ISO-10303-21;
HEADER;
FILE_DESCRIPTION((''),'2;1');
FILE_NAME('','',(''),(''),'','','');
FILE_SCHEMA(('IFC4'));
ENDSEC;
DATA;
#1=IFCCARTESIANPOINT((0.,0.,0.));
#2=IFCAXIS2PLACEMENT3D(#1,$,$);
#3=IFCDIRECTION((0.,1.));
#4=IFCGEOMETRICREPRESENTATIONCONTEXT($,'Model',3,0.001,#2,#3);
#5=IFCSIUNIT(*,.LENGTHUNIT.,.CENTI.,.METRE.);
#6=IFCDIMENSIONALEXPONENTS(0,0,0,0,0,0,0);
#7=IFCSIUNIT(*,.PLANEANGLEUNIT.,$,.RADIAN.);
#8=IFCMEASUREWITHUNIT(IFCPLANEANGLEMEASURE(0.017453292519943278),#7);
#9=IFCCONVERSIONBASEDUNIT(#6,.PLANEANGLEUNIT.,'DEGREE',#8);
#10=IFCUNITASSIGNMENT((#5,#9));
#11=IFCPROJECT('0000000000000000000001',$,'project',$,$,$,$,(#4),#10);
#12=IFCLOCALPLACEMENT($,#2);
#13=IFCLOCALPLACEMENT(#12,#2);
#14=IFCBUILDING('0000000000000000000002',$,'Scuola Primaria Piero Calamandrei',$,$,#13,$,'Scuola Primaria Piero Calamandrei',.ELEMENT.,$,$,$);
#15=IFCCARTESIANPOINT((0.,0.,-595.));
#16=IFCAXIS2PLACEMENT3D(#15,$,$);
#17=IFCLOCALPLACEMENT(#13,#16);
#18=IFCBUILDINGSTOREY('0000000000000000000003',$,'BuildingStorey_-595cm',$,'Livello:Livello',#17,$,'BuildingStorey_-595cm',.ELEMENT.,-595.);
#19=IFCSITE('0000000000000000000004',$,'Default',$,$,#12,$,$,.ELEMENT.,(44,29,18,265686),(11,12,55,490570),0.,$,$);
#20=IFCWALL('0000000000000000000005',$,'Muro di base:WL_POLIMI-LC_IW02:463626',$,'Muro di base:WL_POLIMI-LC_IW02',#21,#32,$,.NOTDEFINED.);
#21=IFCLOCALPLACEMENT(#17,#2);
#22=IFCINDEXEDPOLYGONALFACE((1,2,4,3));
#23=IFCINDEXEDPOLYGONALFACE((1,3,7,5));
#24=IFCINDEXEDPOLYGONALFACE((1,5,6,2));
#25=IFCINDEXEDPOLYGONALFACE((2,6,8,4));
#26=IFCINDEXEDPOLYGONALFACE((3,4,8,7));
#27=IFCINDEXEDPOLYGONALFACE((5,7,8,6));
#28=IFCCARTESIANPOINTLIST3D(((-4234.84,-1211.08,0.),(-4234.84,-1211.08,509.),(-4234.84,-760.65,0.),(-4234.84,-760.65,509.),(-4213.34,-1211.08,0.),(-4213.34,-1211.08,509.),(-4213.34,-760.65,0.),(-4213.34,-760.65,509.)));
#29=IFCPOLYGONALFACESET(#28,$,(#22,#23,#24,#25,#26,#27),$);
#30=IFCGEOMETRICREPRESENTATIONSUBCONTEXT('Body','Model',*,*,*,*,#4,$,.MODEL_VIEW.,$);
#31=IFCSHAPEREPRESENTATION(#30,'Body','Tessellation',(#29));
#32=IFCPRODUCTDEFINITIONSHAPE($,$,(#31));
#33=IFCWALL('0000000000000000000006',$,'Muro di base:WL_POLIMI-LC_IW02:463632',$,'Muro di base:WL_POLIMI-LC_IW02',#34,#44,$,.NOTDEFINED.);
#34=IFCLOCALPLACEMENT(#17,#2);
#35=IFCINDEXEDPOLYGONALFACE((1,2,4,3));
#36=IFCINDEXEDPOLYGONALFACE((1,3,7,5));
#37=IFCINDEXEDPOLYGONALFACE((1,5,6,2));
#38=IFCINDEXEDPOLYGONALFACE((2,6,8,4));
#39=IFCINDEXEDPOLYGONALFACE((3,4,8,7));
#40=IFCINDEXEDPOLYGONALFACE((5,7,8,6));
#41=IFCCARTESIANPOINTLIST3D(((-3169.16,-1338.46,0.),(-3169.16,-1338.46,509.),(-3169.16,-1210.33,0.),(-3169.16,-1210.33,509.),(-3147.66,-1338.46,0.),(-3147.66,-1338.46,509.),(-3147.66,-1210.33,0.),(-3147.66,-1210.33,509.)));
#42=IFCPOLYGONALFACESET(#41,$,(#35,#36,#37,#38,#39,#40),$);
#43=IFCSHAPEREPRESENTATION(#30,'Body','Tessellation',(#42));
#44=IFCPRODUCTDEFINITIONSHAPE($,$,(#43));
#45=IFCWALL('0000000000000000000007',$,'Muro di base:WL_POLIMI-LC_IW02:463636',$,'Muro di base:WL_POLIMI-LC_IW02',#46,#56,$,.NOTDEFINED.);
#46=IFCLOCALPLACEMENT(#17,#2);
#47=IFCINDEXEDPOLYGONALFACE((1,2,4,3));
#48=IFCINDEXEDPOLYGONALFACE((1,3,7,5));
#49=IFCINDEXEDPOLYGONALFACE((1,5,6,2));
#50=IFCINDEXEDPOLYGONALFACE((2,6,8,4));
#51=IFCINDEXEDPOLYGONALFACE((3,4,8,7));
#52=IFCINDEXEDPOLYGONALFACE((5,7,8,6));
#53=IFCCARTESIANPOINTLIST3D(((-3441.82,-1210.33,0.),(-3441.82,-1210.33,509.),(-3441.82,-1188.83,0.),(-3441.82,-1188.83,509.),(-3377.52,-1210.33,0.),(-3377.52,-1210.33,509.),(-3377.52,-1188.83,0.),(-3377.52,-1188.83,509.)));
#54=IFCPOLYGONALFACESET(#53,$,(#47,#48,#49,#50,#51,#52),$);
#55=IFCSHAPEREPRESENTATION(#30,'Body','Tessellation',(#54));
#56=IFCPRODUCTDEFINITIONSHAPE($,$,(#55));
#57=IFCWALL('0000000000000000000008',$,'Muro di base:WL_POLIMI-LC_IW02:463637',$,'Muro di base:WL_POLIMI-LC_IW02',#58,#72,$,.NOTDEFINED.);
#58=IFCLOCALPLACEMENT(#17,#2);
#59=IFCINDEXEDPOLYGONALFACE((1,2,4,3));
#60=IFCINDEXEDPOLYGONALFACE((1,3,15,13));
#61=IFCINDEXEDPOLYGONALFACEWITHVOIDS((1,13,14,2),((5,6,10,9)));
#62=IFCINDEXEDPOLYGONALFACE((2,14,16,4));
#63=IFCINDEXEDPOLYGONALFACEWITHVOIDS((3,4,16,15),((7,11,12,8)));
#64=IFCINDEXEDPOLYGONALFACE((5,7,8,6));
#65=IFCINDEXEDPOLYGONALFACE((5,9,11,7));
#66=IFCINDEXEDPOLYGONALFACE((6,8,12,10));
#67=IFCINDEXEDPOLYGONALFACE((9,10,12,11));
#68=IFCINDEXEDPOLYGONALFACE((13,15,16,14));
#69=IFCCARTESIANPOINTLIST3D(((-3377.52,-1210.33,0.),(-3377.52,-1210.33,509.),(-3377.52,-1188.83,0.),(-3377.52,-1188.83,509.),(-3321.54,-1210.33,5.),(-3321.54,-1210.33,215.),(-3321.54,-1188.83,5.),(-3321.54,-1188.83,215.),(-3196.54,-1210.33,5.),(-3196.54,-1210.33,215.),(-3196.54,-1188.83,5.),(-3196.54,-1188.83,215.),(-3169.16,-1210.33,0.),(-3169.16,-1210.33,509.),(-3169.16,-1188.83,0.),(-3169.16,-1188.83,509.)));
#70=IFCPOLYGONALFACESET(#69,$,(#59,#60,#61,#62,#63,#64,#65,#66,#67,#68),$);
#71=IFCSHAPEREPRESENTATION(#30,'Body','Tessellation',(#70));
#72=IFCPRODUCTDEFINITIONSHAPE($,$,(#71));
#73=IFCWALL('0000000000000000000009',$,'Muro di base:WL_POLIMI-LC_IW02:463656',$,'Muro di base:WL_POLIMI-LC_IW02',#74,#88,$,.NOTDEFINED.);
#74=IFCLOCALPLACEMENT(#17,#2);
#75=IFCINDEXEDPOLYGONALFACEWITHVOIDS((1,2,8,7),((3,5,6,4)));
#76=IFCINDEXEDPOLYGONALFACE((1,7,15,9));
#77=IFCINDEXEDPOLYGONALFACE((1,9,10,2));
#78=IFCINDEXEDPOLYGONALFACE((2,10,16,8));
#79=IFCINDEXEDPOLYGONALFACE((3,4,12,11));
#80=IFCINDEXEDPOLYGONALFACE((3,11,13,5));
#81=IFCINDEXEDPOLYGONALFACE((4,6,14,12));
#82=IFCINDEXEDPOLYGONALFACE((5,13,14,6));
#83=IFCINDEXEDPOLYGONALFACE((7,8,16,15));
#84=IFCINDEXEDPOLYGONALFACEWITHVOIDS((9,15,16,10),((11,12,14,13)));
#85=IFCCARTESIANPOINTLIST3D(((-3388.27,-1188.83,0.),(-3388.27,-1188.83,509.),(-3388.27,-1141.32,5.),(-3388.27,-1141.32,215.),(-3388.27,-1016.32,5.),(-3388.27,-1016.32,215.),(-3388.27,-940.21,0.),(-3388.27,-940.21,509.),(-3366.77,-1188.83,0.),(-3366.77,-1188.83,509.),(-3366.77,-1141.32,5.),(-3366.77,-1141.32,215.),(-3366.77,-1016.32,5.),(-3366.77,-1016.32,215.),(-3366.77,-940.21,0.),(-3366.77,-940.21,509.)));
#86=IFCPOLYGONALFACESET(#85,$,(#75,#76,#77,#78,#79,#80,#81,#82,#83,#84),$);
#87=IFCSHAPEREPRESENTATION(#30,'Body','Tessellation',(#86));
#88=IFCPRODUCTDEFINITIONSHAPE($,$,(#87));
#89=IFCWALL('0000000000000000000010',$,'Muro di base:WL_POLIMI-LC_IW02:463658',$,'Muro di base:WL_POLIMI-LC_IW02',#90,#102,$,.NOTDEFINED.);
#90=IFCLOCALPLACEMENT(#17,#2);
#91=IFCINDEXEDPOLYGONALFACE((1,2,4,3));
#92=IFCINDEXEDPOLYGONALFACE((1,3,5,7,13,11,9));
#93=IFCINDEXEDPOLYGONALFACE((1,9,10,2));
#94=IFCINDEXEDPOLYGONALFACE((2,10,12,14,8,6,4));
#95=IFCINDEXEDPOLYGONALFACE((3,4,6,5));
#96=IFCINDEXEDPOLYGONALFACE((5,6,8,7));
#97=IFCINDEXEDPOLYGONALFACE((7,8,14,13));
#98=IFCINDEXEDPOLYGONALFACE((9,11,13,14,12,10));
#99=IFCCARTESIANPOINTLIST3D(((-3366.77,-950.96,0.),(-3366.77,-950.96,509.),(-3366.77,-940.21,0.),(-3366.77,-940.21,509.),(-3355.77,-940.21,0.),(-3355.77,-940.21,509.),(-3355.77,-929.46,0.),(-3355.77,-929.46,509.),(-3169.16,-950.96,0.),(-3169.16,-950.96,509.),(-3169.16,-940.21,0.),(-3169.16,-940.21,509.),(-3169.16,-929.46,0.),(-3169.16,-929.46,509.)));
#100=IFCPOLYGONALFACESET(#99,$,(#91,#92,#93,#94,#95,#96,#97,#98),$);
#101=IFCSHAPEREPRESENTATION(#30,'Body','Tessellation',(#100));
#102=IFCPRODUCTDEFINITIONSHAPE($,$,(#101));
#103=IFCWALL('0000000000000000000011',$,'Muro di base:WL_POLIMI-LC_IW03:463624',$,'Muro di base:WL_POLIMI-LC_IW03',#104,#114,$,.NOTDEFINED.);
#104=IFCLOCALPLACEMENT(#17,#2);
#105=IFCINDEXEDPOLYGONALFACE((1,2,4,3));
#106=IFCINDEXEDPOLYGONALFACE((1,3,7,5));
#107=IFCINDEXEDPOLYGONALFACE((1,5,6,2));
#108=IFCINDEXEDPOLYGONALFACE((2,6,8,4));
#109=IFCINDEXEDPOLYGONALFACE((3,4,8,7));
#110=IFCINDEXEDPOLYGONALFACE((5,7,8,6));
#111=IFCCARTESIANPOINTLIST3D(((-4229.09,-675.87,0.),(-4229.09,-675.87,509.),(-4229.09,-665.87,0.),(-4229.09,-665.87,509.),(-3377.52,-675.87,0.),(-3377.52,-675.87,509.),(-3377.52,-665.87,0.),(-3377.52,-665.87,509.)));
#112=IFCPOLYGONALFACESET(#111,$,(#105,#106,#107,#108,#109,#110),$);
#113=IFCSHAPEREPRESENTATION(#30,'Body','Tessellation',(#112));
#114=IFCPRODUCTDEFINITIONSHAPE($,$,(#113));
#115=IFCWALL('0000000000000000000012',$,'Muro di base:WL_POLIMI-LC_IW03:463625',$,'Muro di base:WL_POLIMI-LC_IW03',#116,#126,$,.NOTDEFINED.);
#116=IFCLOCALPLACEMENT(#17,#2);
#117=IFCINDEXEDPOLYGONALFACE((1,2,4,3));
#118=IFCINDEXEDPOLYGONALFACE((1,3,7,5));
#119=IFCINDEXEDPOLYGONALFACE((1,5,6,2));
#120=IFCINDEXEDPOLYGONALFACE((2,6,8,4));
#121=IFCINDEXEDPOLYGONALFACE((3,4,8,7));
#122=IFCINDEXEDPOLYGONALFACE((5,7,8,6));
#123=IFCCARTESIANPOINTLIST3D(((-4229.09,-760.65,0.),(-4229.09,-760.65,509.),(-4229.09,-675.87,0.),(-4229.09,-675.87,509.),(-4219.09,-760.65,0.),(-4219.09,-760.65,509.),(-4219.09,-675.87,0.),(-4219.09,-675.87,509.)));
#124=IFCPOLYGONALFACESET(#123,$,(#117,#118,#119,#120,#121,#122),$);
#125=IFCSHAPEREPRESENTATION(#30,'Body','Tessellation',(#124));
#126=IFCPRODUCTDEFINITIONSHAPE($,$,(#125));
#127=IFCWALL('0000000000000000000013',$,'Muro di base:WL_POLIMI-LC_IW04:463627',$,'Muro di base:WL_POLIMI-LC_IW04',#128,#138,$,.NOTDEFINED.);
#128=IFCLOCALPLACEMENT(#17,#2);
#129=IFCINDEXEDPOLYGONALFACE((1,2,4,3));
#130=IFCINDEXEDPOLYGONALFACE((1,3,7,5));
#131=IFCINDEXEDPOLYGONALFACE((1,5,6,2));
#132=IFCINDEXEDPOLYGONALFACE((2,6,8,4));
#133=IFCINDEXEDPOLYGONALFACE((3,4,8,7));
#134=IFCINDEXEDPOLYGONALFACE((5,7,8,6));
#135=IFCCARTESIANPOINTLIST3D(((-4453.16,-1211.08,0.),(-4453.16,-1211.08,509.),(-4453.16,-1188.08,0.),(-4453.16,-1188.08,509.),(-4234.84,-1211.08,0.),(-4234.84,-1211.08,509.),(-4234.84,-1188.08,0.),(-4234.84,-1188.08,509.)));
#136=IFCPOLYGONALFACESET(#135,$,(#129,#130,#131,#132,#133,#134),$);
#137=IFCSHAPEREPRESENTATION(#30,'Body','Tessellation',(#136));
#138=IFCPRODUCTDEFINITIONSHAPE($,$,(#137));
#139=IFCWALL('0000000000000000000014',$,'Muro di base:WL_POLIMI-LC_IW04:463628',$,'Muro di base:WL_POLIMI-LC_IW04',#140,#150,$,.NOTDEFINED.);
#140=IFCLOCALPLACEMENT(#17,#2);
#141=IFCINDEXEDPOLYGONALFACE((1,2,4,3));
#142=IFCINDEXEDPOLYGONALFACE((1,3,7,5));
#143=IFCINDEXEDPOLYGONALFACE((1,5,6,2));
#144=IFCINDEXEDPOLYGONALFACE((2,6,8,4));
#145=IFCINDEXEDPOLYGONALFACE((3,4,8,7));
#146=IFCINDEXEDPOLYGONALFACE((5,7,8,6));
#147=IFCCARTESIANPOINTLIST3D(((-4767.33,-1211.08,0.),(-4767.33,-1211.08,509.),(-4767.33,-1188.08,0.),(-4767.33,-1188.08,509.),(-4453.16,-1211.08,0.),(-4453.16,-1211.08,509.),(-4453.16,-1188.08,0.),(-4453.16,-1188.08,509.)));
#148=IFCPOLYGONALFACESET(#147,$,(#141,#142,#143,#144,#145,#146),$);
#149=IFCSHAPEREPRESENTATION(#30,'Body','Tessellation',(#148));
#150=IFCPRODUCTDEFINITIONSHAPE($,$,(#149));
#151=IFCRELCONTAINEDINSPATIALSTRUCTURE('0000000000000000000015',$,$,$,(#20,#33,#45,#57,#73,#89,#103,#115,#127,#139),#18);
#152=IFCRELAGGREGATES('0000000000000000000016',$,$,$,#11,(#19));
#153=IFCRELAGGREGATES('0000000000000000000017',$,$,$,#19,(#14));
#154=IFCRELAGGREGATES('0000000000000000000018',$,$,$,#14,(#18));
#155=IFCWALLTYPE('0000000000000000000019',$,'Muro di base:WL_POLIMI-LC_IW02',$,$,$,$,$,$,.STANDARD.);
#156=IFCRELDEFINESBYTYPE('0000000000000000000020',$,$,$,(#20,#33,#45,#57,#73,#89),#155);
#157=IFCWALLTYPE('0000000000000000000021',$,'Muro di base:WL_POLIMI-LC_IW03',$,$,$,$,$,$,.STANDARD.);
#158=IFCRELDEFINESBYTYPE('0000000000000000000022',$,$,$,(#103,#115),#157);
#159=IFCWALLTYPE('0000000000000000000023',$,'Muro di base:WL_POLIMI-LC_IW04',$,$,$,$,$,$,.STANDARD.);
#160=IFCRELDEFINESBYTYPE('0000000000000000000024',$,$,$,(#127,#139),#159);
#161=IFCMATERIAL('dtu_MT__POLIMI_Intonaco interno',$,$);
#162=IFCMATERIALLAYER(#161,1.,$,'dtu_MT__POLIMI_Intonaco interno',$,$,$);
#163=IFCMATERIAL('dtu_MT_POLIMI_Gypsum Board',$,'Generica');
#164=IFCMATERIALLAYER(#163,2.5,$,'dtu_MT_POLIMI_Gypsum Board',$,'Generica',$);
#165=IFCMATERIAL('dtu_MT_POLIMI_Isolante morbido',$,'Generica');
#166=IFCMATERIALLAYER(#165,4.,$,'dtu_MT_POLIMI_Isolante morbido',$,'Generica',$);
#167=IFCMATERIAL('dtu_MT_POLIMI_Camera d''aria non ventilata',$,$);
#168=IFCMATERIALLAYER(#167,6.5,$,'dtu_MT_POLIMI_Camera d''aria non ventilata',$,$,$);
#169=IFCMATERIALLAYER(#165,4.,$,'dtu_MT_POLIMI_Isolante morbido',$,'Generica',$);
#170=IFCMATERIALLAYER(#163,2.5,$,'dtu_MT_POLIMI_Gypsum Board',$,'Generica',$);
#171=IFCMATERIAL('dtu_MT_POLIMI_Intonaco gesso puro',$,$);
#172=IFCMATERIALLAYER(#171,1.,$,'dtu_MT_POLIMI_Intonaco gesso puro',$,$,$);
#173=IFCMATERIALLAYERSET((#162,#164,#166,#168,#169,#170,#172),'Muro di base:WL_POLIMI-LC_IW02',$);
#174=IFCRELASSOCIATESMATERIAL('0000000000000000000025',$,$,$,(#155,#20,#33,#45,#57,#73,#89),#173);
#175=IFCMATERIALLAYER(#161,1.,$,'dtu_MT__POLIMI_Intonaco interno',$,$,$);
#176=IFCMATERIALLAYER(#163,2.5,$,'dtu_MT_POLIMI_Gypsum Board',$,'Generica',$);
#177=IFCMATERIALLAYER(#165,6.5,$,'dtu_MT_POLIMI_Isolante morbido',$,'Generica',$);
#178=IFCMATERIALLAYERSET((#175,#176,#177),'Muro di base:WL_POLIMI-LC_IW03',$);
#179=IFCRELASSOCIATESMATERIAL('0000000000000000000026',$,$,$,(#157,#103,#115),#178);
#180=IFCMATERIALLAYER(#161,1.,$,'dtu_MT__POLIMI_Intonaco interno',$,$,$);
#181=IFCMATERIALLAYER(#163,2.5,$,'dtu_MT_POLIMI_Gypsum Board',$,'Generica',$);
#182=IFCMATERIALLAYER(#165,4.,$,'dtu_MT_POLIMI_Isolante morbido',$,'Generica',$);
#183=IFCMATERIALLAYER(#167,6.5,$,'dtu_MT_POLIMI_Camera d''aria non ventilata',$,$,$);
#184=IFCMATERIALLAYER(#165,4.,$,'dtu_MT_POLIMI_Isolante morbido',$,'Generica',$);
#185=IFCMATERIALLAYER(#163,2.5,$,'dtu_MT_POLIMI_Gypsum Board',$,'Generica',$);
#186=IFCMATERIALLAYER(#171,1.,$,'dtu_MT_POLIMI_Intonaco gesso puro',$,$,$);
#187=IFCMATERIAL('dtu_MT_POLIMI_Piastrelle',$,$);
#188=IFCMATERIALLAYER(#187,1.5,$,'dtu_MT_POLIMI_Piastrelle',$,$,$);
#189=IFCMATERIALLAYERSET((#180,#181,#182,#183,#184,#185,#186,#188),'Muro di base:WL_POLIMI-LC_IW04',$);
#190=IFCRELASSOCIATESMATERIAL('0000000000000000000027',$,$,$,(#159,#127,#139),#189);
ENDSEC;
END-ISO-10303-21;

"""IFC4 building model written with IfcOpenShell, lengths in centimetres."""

from ifc_helpers import new_model, entity, si_unit, converted_unit, direction, frame, frame_2d, origin, place, context, subcontext, project, spatial, polyline, rectangle, outline, extrude, material, layer, layer_set, layer_usage, type_object, element, save


model = new_model("IFC4")

# Units and contexts
model_context = context("Model", 3, precision=0.001, world=origin(), true_north=direction((0.0, 1.0)))
body_context = subcontext(model_context, "Body", "Model", "MODEL_VIEW")
ifc_project = project(units=[si_unit("LENGTHUNIT", "METRE", prefix="CENTI"), converted_unit("PLANEANGLEUNIT", "DEGREE", entity("IfcPlaneAngleMeasure", 0.017453292519943278), si_unit("PLANEANGLEUNIT", "RADIAN"), dimensions=[0, 0, 0, 0, 0, 0, 0])], contexts=[model_context])

# Site, building, storey
site_placement = place(None, origin())
site = spatial("IfcSite", under=ifc_project, at=site_placement, Name="Default", CompositionType="ELEMENT", RefLatitude=(44, 29, 18, 265686), RefLongitude=(11, 12, 55, 490570), RefElevation=0.0)
building_placement = place(site_placement, origin())
building = spatial("IfcBuilding", under=site, at=building_placement, Name="Scuola Primaria Piero Calamandrei", LongName="Scuola Primaria Piero Calamandrei", CompositionType="ELEMENT")
storey_placement = place(building_placement, frame((0.0, 0.0, -595.0)))
storey = spatial("IfcBuildingStorey", under=building, at=storey_placement, Name="BuildingStorey_-595cm", ObjectType="Livello:Livello", LongName="BuildingStorey_-595cm", CompositionType="ELEMENT", Elevation=-595.0)

# Shared definitions
ifc_material_1 = material(Name="dtu_MT__POLIMI_Intonaco interno")
ifc_layer_1 = layer(ifc_material_1, 1.0, Name="dtu_MT__POLIMI_Intonaco interno")
ifc_material_2 = material(Name="dtu_MT_POLIMI_Gypsum Board", Category="Generica")
ifc_layer_2 = layer(ifc_material_2, 2.5, Name="dtu_MT_POLIMI_Gypsum Board", Category="Generica")
ifc_material_3 = material(Name="dtu_MT_POLIMI_Isolante morbido", Category="Generica")
ifc_layer_3 = layer(ifc_material_3, 4.0, Name="dtu_MT_POLIMI_Isolante morbido", Category="Generica")
ifc_material_4 = material(Name="dtu_MT_POLIMI_Camera d'aria non ventilata")
ifc_layer_4 = layer(ifc_material_4, 6.5, Name="dtu_MT_POLIMI_Camera d'aria non ventilata")
ifc_layer_5 = layer(ifc_material_3, 4.0, Name="dtu_MT_POLIMI_Isolante morbido", Category="Generica")
ifc_layer_6 = layer(ifc_material_2, 2.5, Name="dtu_MT_POLIMI_Gypsum Board", Category="Generica")
ifc_material_5 = material(Name="dtu_MT_POLIMI_Intonaco gesso puro")
ifc_layer_7 = layer(ifc_material_5, 1.0, Name="dtu_MT_POLIMI_Intonaco gesso puro")
ifc_layer_set_1 = layer_set([ifc_layer_1, ifc_layer_2, ifc_layer_3, ifc_layer_4, ifc_layer_5, ifc_layer_6, ifc_layer_7], Name="Muro di base:WL_POLIMI-LC_IW02")
wall_type_1 = type_object("IfcWallType", Name="Muro di base:WL_POLIMI-LC_IW02", PredefinedType="STANDARD", material=ifc_layer_set_1)

# Walls
ifc_layer_usage_1 = layer_usage(ifc_layer_set_1, "AXIS2", "NEGATIVE", 10.75)
wall_1_placement = place(storey_placement, frame((-4224.09, -760.65, 0.0), z_axis=(0.0, 0.0, 1.0), x_axis=(0.0, -1.0, 0.0)))
element("IfcWall", 1, at=wall_1_placement, inside=storey, type_object=wall_type_1, material=ifc_layer_usage_1, Name="Muro di base:WL_POLIMI-LC_IW02:463626", ObjectType="Muro di base:WL_POLIMI-LC_IW02", PredefinedType="NOTDEFINED", context=body_context, shape_type="SweptSolid", body=[
    extrude(rectangle(XDim=450.42, YDim=21.5, at=frame_2d((225.21, 0.0), x_axis=(-1.0, 0.0))), origin(), (0.0, 0.0, 1.0), 509.0),
])
ifc_layer_usage_2 = layer_usage(ifc_layer_set_1, "AXIS2", "NEGATIVE", 10.75)
wall_2_placement = place(storey_placement, frame((-3158.41, -1338.46, 0.0), z_axis=(0.0, 0.0, 1.0), x_axis=(0.0, 1.0, 0.0)))
element("IfcWall", 2, at=wall_2_placement, inside=storey, type_object=wall_type_1, material=ifc_layer_usage_2, Name="Muro di base:WL_POLIMI-LC_IW02:463632", ObjectType="Muro di base:WL_POLIMI-LC_IW02", PredefinedType="NOTDEFINED", context=body_context, shape_type="SweptSolid", body=[
    extrude(rectangle(XDim=128.13, YDim=21.5, at=frame_2d((64.07, 0.0), x_axis=(-1.0, 0.0))), origin(), (0.0, 0.0, 1.0), 509.0),
])
ifc_layer_usage_3 = layer_usage(ifc_layer_set_1, "AXIS2", "NEGATIVE", 10.75)
wall_3_placement = place(storey_placement, frame((-3441.82, -1199.58, 0.0)))
element("IfcWall", 3, at=wall_3_placement, inside=storey, type_object=wall_type_1, material=ifc_layer_usage_3, Name="Muro di base:WL_POLIMI-LC_IW02:463636", ObjectType="Muro di base:WL_POLIMI-LC_IW02", PredefinedType="NOTDEFINED", context=body_context, shape_type="SweptSolid", body=[
    extrude(rectangle(XDim=64.3, YDim=21.5, at=frame_2d((32.15, 0.0), x_axis=(-1.0, 0.0))), origin(), (0.0, 0.0, 1.0), 509.0),
])

# Walls, openings
ifc_layer_usage_4 = layer_usage(ifc_layer_set_1, "AXIS2", "NEGATIVE", 10.75)
wall_4_placement = place(storey_placement, frame((-3377.52, -1199.58, 0.0)))
wall_4 = element("IfcWall", 4, at=wall_4_placement, inside=storey, type_object=wall_type_1, material=ifc_layer_usage_4, Name="Muro di base:WL_POLIMI-LC_IW02:463637", ObjectType="Muro di base:WL_POLIMI-LC_IW02", PredefinedType="NOTDEFINED", context=body_context, shape_type="SweptSolid", body=[
    extrude(rectangle(XDim=208.36, YDim=21.5, at=frame_2d((104.18, 0.0), x_axis=(-1.0, 0.0))), origin(), (0.0, 0.0, 1.0), 509.0),
])
opening_1_placement = place(wall_4_placement, frame((180.98, 10.75, 5.0)))
element("IfcOpeningElement", 5, at=opening_1_placement, cuts=wall_4, PredefinedType="OPENING", context=body_context, shape_type="SweptSolid", body=[
    extrude(rectangle(XDim=210.0, YDim=125.0, at=frame_2d((105.0, 62.5), x_axis=(-1.0, 0.0))), frame((0.0, 0.0, 0.0), z_axis=(0.0, -1.0, 0.0), x_axis=(0.0, 0.0, 1.0)), (0.0, 0.0, 1.0), 21.5),
])
ifc_layer_usage_5 = layer_usage(ifc_layer_set_1, "AXIS2", "NEGATIVE", 10.75)
wall_5_placement = place(storey_placement, frame((-3377.52, -940.21, 0.0), z_axis=(0.0, 0.0, 1.0), x_axis=(0.0, -1.0, 0.0)))
wall_5 = element("IfcWall", 6, at=wall_5_placement, inside=storey, type_object=wall_type_1, material=ifc_layer_usage_5, Name="Muro di base:WL_POLIMI-LC_IW02:463656", ObjectType="Muro di base:WL_POLIMI-LC_IW02", PredefinedType="NOTDEFINED", context=body_context, shape_type="SweptSolid", body=[
    extrude(rectangle(XDim=248.61, YDim=21.5, at=frame_2d((124.31, 0.0), x_axis=(-1.0, 0.0))), origin(), (0.0, 0.0, 1.0), 509.0),
])
opening_2_placement = place(wall_5_placement, frame((201.11, 10.75, 5.0)))
element("IfcOpeningElement", 7, at=opening_2_placement, cuts=wall_5, PredefinedType="OPENING", context=body_context, shape_type="SweptSolid", body=[
    extrude(rectangle(XDim=210.0, YDim=125.0, at=frame_2d((105.0, 62.5), x_axis=(-1.0, 0.0))), frame((0.0, 0.0, 0.0), z_axis=(0.0, -1.0, 0.0), x_axis=(0.0, 0.0, 1.0)), (0.0, 0.0, 1.0), 21.5),
])

# Walls
ifc_layer_usage_6 = layer_usage(ifc_layer_set_1, "AXIS2", "NEGATIVE", 10.75)
wall_6_placement = place(storey_placement, frame((-3366.77, -940.21, 0.0)))
element("IfcWall", 8, at=wall_6_placement, inside=storey, type_object=wall_type_1, material=ifc_layer_usage_6, Name="Muro di base:WL_POLIMI-LC_IW02:463658", ObjectType="Muro di base:WL_POLIMI-LC_IW02", PredefinedType="NOTDEFINED", context=body_context, shape_type="SweptSolid", body=[
    extrude(outline(polyline([(-10.75, -109.78), (0.0, -109.78), (10.75, -109.78), (10.75, 76.83), (0.0, 76.83), (0.0, 87.83), (-10.75, 87.83), (-10.75, -109.78)])), frame((87.83, 0.0, 0.0), z_axis=(0.0, 0.0, 1.0), x_axis=(0.0, 1.0, 0.0)), (0.0, 0.0, 1.0), 509.0),
])
ifc_layer_8 = layer(ifc_material_1, 1.0, Name="dtu_MT__POLIMI_Intonaco interno")
ifc_layer_9 = layer(ifc_material_2, 2.5, Name="dtu_MT_POLIMI_Gypsum Board", Category="Generica")
ifc_layer_10 = layer(ifc_material_3, 6.5, Name="dtu_MT_POLIMI_Isolante morbido", Category="Generica")
ifc_layer_set_2 = layer_set([ifc_layer_8, ifc_layer_9, ifc_layer_10], Name="Muro di base:WL_POLIMI-LC_IW03")
ifc_layer_usage_7 = layer_usage(ifc_layer_set_2, "AXIS2", "NEGATIVE", 5.0)
wall_type_2 = type_object("IfcWallType", Name="Muro di base:WL_POLIMI-LC_IW03", PredefinedType="STANDARD", material=ifc_layer_set_2)
wall_7_placement = place(storey_placement, frame((-3377.52, -670.87, 0.0), z_axis=(0.0, 0.0, 1.0), x_axis=(-1.0, 0.0, 0.0)))
element("IfcWall", 9, at=wall_7_placement, inside=storey, type_object=wall_type_2, material=ifc_layer_usage_7, Name="Muro di base:WL_POLIMI-LC_IW03:463624", ObjectType="Muro di base:WL_POLIMI-LC_IW03", PredefinedType="NOTDEFINED", context=body_context, shape_type="SweptSolid", body=[
    extrude(rectangle(XDim=851.57, YDim=10.0, at=frame_2d((425.78, 0.0), x_axis=(-1.0, 0.0))), origin(), (0.0, 0.0, 1.0), 509.0),
])
ifc_layer_usage_8 = layer_usage(ifc_layer_set_2, "AXIS2", "NEGATIVE", 5.0)
wall_8_placement = place(storey_placement, frame((-4224.09, -675.87, 0.0), z_axis=(0.0, 0.0, 1.0), x_axis=(0.0, -1.0, 0.0)))
element("IfcWall", 10, at=wall_8_placement, inside=storey, type_object=wall_type_2, material=ifc_layer_usage_8, Name="Muro di base:WL_POLIMI-LC_IW03:463625", ObjectType="Muro di base:WL_POLIMI-LC_IW03", PredefinedType="NOTDEFINED", context=body_context, shape_type="SweptSolid", body=[
    extrude(rectangle(XDim=84.78, YDim=10.0, at=frame_2d((42.39, 0.0), x_axis=(-1.0, 0.0))), origin(), (0.0, 0.0, 1.0), 509.0),
])
ifc_layer_11 = layer(ifc_material_1, 1.0, Name="dtu_MT__POLIMI_Intonaco interno")
ifc_layer_12 = layer(ifc_material_2, 2.5, Name="dtu_MT_POLIMI_Gypsum Board", Category="Generica")
ifc_layer_13 = layer(ifc_material_3, 4.0, Name="dtu_MT_POLIMI_Isolante morbido", Category="Generica")
ifc_layer_14 = layer(ifc_material_4, 6.5, Name="dtu_MT_POLIMI_Camera d'aria non ventilata")
ifc_layer_15 = layer(ifc_material_3, 4.0, Name="dtu_MT_POLIMI_Isolante morbido", Category="Generica")
ifc_layer_16 = layer(ifc_material_2, 2.5, Name="dtu_MT_POLIMI_Gypsum Board", Category="Generica")
ifc_layer_17 = layer(ifc_material_5, 1.0, Name="dtu_MT_POLIMI_Intonaco gesso puro")
ifc_material_6 = material(Name="dtu_MT_POLIMI_Piastrelle")
ifc_layer_18 = layer(ifc_material_6, 1.5, Name="dtu_MT_POLIMI_Piastrelle")
ifc_layer_set_3 = layer_set([ifc_layer_11, ifc_layer_12, ifc_layer_13, ifc_layer_14, ifc_layer_15, ifc_layer_16, ifc_layer_17, ifc_layer_18], Name="Muro di base:WL_POLIMI-LC_IW04")
ifc_layer_usage_9 = layer_usage(ifc_layer_set_3, "AXIS2", "NEGATIVE", 11.5)
wall_type_3 = type_object("IfcWallType", Name="Muro di base:WL_POLIMI-LC_IW04", PredefinedType="STANDARD", material=ifc_layer_set_3)
wall_9_placement = place(storey_placement, frame((-4234.84, -1199.58, 0.0), z_axis=(0.0, 0.0, 1.0), x_axis=(-1.0, 0.0, 0.0)))
element("IfcWall", 11, at=wall_9_placement, inside=storey, type_object=wall_type_3, material=ifc_layer_usage_9, Name="Muro di base:WL_POLIMI-LC_IW04:463627", ObjectType="Muro di base:WL_POLIMI-LC_IW04", PredefinedType="NOTDEFINED", context=body_context, shape_type="SweptSolid", body=[
    extrude(rectangle(XDim=218.32, YDim=23.0, at=frame_2d((109.16, 0.0), x_axis=(-1.0, 0.0))), origin(), (0.0, 0.0, 1.0), 509.0),
])
ifc_layer_usage_10 = layer_usage(ifc_layer_set_3, "AXIS2", "NEGATIVE", 11.5)
wall_10_placement = place(storey_placement, frame((-4453.16, -1199.58, 0.0), z_axis=(0.0, 0.0, 1.0), x_axis=(-1.0, 0.0, 0.0)))
element("IfcWall", 12, at=wall_10_placement, inside=storey, type_object=wall_type_3, material=ifc_layer_usage_10, Name="Muro di base:WL_POLIMI-LC_IW04:463628", ObjectType="Muro di base:WL_POLIMI-LC_IW04", PredefinedType="NOTDEFINED", context=body_context, shape_type="SweptSolid", body=[
    extrude(rectangle(XDim=314.17, YDim=23.0, at=frame_2d((157.08, 0.0), x_axis=(-1.0, 0.0))), origin(), (0.0, 0.0, 1.0), 509.0),
])

save(model, "model.ifc")
